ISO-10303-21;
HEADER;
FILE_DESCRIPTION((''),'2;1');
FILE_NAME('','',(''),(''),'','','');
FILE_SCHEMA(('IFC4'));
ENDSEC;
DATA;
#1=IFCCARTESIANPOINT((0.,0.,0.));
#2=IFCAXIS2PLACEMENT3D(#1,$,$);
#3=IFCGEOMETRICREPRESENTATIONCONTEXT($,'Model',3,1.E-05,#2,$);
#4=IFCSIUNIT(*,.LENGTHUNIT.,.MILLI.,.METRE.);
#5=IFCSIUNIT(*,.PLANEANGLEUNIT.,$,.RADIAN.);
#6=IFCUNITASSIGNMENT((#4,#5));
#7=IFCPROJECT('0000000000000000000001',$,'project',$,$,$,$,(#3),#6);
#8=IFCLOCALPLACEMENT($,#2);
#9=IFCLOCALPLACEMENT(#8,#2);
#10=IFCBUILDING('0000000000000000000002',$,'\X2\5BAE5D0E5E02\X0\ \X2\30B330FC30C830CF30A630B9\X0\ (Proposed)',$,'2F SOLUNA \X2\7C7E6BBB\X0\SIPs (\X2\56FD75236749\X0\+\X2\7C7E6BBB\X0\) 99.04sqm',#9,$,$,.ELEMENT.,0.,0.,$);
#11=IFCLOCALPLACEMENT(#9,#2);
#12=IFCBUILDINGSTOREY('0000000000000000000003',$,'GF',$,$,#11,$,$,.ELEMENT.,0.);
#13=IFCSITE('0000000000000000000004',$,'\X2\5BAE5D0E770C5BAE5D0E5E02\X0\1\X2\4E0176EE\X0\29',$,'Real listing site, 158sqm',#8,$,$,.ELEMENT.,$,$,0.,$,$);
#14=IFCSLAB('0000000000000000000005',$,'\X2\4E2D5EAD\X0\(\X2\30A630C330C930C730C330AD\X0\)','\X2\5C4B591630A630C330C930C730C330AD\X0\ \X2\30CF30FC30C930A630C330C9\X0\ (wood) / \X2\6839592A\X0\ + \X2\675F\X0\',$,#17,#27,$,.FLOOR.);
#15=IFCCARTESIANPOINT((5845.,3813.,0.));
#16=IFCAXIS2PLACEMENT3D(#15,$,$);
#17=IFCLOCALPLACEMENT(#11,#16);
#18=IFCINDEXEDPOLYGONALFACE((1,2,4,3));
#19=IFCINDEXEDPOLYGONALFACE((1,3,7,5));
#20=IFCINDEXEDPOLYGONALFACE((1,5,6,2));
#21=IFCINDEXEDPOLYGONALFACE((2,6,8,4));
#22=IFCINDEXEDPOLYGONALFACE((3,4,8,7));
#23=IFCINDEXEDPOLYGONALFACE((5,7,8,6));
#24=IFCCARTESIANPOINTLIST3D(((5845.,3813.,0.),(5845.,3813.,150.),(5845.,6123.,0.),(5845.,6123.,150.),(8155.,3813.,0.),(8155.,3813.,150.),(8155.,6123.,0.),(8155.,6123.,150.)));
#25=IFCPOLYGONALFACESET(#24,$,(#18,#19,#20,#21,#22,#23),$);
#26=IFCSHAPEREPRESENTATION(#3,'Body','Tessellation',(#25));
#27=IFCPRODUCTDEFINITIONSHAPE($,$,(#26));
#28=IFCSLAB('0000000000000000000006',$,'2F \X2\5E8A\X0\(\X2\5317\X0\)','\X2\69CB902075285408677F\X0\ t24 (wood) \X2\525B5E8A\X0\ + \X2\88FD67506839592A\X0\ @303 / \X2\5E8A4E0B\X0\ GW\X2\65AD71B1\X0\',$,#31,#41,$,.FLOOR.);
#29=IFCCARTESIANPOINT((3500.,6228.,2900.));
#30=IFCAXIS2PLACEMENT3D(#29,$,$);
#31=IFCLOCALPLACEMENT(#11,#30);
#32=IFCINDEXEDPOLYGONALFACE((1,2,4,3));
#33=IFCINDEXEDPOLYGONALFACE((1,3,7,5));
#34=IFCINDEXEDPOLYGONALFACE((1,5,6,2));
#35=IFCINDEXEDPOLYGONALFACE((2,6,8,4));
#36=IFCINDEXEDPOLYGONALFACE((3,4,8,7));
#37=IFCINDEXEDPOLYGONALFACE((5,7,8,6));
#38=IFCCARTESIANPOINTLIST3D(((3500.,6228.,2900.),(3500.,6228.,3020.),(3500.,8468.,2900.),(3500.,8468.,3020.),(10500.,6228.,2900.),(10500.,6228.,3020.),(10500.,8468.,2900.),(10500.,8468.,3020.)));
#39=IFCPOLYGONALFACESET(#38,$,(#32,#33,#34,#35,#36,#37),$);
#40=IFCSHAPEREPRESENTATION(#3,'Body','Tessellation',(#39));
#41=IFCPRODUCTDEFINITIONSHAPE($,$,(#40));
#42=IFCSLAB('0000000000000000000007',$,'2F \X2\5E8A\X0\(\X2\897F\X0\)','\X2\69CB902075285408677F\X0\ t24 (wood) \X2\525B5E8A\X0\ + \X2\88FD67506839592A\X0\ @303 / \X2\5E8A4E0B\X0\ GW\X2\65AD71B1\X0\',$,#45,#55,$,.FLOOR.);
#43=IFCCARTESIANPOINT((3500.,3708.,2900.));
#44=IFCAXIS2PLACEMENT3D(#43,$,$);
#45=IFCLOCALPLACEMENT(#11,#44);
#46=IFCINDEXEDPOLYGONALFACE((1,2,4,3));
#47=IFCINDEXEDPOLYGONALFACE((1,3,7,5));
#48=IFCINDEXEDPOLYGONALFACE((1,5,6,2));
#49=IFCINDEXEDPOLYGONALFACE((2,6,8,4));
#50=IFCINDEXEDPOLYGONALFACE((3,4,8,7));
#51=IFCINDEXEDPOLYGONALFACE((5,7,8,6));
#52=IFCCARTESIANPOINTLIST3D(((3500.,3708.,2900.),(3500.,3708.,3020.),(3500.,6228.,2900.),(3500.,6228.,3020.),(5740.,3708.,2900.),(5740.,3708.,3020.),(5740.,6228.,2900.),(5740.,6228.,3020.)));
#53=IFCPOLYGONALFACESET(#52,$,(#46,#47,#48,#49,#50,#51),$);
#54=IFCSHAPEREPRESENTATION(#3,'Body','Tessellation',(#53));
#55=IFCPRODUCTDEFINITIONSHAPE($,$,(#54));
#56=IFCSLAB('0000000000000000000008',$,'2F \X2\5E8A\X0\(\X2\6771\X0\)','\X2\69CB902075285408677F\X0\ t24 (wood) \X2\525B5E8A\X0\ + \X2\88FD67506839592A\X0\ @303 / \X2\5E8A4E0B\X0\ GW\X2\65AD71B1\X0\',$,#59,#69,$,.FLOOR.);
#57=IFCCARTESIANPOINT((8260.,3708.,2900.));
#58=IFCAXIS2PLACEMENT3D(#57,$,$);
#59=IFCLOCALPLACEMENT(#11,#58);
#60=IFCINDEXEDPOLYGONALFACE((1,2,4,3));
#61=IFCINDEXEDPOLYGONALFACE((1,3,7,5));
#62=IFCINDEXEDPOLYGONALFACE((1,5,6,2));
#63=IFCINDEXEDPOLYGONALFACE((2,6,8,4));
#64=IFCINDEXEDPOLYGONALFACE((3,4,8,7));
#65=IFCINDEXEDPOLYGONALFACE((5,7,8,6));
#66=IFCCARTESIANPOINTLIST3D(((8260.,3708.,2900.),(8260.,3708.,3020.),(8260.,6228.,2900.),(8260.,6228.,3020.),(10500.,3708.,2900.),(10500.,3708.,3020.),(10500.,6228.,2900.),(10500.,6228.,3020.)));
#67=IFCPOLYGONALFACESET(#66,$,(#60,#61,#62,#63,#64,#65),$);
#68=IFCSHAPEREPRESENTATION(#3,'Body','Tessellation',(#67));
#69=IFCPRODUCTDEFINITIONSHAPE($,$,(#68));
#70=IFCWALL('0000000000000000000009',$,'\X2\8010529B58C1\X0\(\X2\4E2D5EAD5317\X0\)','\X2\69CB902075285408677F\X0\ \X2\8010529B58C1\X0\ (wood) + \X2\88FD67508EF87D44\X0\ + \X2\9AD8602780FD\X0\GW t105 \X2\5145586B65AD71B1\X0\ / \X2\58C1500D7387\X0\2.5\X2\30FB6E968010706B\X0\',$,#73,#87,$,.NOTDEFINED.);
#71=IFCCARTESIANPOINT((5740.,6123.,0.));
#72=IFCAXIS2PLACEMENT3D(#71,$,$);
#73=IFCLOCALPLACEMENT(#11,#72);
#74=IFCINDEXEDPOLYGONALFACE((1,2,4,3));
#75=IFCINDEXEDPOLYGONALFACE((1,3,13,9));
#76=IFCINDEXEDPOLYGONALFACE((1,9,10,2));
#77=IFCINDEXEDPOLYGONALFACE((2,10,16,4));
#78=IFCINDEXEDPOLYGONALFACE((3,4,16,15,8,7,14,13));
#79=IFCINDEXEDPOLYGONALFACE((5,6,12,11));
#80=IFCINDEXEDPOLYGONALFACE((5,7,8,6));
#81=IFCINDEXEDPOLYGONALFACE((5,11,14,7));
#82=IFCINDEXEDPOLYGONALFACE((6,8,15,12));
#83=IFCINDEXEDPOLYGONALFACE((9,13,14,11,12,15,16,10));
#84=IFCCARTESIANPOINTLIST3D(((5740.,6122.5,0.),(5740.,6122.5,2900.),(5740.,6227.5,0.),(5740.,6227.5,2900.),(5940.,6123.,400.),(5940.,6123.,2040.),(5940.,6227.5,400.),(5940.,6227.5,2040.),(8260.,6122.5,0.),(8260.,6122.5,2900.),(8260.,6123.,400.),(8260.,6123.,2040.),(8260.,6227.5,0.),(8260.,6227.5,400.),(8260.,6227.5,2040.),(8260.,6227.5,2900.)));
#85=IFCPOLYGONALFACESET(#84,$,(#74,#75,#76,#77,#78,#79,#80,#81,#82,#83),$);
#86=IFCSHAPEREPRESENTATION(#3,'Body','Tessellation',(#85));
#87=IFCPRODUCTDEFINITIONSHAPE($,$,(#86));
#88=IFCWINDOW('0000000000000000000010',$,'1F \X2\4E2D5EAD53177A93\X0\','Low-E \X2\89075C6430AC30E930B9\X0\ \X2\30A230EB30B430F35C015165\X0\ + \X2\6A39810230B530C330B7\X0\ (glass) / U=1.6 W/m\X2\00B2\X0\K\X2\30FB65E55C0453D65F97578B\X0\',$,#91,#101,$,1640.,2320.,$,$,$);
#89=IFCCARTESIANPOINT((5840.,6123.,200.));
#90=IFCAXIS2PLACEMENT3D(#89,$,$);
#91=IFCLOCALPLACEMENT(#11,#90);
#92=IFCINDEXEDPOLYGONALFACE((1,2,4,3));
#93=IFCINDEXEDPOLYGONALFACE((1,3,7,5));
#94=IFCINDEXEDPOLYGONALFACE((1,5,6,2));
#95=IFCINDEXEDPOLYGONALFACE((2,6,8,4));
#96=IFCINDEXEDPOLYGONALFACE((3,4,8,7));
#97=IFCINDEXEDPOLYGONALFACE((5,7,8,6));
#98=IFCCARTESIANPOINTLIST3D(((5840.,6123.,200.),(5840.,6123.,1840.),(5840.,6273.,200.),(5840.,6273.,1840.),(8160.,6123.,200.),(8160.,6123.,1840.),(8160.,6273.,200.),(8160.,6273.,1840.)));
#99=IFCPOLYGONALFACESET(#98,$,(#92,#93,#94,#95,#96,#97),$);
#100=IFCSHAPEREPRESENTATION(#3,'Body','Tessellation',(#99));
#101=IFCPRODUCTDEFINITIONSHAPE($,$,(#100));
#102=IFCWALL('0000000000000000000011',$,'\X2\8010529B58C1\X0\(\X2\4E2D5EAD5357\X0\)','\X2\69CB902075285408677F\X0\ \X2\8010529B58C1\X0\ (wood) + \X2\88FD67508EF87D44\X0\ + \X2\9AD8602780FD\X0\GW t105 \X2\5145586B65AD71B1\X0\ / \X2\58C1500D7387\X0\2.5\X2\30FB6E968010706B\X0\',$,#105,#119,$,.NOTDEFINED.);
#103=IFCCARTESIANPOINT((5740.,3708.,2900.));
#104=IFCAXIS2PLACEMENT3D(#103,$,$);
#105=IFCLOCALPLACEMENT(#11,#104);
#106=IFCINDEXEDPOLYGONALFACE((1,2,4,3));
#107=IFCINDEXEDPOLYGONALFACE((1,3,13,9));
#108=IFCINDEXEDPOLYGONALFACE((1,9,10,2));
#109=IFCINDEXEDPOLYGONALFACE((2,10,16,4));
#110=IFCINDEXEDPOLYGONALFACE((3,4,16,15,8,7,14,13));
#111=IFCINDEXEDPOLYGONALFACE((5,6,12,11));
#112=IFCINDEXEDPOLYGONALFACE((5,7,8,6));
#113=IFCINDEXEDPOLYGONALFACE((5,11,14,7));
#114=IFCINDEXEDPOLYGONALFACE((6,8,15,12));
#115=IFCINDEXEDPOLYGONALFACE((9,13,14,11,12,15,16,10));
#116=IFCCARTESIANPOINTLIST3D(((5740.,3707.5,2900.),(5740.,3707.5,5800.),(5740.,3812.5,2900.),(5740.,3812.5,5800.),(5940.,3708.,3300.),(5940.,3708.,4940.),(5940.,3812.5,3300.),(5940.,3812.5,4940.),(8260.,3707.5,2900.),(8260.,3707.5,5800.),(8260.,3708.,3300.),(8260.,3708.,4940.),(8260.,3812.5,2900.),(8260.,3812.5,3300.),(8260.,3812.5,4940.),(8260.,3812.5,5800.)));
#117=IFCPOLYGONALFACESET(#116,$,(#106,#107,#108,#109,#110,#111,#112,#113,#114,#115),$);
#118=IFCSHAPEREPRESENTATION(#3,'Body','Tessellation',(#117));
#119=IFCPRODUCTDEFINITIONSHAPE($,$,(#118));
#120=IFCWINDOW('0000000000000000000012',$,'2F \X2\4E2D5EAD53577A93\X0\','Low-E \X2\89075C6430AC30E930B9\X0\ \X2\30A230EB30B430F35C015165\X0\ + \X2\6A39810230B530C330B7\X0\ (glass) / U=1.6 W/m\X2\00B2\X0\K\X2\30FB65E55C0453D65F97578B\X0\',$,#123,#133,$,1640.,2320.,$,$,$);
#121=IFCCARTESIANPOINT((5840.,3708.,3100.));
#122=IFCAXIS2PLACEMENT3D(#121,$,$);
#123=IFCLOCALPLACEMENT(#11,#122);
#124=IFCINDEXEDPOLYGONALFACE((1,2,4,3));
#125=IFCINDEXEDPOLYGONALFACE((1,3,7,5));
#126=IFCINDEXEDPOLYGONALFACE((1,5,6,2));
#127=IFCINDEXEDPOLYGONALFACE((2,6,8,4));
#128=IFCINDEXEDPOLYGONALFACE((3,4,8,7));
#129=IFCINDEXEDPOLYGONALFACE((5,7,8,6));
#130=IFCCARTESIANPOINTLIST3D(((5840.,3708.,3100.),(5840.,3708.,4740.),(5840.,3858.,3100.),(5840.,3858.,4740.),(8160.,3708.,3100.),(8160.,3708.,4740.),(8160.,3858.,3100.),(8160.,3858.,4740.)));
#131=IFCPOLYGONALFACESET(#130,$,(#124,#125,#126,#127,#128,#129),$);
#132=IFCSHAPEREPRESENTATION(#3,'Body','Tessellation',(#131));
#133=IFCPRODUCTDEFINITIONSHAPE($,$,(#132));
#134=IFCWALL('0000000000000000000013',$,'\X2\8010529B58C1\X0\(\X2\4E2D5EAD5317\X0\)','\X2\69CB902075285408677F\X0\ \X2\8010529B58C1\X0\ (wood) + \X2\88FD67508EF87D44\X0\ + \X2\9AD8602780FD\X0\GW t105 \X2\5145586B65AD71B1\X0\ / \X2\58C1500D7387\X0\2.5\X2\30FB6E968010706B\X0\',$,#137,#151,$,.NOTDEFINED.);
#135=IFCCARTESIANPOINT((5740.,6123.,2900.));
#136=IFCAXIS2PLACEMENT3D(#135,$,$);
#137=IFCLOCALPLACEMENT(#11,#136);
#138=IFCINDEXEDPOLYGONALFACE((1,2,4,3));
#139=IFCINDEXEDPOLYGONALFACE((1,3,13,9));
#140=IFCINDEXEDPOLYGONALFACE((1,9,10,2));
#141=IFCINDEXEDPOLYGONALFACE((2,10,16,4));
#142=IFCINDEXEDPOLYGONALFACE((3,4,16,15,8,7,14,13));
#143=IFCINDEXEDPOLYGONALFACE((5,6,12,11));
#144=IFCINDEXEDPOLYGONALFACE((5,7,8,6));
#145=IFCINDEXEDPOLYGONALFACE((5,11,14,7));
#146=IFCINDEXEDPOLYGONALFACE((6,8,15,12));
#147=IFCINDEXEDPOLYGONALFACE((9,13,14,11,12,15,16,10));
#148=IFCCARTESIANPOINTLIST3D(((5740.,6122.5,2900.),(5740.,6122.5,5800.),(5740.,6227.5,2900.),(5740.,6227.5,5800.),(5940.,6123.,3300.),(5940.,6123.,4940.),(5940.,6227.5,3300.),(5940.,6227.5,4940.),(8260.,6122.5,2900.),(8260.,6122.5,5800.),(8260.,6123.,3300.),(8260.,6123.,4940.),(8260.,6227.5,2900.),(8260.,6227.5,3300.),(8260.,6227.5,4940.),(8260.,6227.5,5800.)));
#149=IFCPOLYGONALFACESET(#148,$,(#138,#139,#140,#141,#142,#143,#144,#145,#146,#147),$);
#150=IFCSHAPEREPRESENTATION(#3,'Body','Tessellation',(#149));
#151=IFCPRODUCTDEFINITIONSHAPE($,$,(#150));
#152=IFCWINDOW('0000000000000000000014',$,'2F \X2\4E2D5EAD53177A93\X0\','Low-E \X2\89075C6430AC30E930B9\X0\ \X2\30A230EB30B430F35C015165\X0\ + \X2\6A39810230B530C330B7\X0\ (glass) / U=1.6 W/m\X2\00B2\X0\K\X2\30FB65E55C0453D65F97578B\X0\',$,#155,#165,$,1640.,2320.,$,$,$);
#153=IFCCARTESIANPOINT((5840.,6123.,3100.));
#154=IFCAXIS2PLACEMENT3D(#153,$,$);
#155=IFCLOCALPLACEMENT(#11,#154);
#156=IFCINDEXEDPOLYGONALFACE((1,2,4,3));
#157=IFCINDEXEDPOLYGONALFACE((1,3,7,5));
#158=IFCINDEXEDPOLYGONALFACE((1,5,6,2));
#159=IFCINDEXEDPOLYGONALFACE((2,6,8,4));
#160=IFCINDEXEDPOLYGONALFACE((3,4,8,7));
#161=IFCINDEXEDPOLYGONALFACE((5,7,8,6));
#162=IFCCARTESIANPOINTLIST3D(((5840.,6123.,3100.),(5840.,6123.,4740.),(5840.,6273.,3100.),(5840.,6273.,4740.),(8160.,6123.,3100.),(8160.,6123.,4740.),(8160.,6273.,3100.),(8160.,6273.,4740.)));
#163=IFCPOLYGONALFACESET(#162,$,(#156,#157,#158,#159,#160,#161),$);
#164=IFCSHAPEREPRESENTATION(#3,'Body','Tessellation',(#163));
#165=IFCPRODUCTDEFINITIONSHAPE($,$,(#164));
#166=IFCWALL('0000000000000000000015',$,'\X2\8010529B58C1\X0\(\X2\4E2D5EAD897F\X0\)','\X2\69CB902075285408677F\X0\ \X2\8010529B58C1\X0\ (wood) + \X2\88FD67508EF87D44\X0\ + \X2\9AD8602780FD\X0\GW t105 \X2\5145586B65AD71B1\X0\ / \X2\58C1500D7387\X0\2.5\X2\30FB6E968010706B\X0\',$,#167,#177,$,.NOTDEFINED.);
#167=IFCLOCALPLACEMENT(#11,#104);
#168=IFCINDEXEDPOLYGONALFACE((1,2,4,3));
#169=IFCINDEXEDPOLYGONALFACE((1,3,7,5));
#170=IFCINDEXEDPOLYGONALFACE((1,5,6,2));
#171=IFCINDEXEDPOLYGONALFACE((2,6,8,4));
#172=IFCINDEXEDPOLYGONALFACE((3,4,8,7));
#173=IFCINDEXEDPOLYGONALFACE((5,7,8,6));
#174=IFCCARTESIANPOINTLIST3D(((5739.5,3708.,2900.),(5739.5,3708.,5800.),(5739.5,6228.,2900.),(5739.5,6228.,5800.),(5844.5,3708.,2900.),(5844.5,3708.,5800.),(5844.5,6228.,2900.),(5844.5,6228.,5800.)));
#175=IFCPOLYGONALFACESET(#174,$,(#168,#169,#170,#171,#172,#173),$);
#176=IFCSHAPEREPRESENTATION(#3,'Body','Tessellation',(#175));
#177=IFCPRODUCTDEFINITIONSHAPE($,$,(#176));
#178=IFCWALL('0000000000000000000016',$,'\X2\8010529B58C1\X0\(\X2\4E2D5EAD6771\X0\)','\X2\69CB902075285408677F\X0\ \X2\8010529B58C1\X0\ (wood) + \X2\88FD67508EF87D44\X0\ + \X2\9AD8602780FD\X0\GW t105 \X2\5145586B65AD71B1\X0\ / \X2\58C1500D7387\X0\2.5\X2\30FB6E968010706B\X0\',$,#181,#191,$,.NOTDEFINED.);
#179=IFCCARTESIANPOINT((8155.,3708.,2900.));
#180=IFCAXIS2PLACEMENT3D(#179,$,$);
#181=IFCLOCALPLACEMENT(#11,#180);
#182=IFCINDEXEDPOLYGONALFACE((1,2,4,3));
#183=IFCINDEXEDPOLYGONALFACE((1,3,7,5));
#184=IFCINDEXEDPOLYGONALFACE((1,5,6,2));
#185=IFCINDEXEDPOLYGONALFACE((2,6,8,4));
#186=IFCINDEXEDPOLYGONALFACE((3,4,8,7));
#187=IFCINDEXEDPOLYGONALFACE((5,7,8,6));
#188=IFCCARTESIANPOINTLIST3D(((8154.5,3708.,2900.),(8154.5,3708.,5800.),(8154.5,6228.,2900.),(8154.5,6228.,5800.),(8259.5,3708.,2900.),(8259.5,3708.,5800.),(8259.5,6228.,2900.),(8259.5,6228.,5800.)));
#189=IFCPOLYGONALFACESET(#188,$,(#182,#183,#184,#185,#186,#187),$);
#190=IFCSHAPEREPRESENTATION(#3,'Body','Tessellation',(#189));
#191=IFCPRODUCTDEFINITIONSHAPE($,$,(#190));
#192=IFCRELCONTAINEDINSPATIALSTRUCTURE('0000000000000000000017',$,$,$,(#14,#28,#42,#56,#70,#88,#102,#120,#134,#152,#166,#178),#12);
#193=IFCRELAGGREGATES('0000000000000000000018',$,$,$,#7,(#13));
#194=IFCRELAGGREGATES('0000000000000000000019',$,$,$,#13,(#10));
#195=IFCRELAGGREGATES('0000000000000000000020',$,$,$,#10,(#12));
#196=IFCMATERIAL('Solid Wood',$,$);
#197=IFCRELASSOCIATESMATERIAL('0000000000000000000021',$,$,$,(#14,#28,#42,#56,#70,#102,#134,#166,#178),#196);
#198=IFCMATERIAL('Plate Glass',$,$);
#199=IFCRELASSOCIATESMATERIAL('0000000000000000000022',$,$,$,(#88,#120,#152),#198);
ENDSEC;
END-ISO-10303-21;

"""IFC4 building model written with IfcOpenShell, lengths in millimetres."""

from ifc_helpers import new_model, si_unit, frame, frame_2d, origin, place, context, project, spatial, rectangle, extrude, material, element, fill, save


model = new_model("IFC4")

# Units and contexts
model_context = context("Model", 3, precision=1e-05, world=origin())
ifc_project = project(units=[si_unit("LENGTHUNIT", "METRE", prefix="MILLI"), si_unit("PLANEANGLEUNIT", "RADIAN")], contexts=[model_context])

# Site, building, storey
site_placement = place(None, origin())
site = spatial("IfcSite", under=ifc_project, at=site_placement, Name="宮崎県宮崎市1丁目29", ObjectType="Real listing site, 158sqm", CompositionType="ELEMENT", RefElevation=0.0)
building_placement = place(site_placement, origin())
building = spatial("IfcBuilding", under=site, at=building_placement, Name="宮崎市 コートハウス (Proposed)", ObjectType="2F SOLUNA 籾殻SIPs (国産杉+籾殻) 99.04sqm", CompositionType="ELEMENT", ElevationOfRefHeight=0.0, ElevationOfTerrain=0.0)
storey_placement = place(building_placement, origin())
storey = spatial("IfcBuildingStorey", under=building, at=storey_placement, Name="GF", CompositionType="ELEMENT", Elevation=0.0)

# Slabs
ifc_material_1 = material(Name="Solid Wood")
slab_1_placement = place(storey_placement, frame((5845.0, 3813.0, 0.0)))
element("IfcSlab", 1, at=slab_1_placement, inside=storey, material=ifc_material_1, Name="中庭(ウッドデッキ)", Description="屋外ウッドデッキ ハードウッド (wood) / 根太 + 束", PredefinedType="FLOOR", context=model_context, shape_type="SweptSolid", body=[
    extrude(rectangle(XDim=2310.0, YDim=2310.0, at=frame_2d((1155.0, 1155.0))), frame((5845.0, 3813.0, 0.0)), (0.0, 0.0, 1.0), 150.0),
])
slab_2_placement = place(storey_placement, frame((3500.0, 6228.0, 2900.0)))
element("IfcSlab", 2, at=slab_2_placement, inside=storey, material=ifc_material_1, Name="2F 床(北)", Description="構造用合板 t24 (wood) 剛床 + 製材根太 @303 / 床下 GW断熱", PredefinedType="FLOOR", context=model_context, shape_type="SweptSolid", body=[
    extrude(rectangle(XDim=7000.0, YDim=2240.0, at=frame_2d((3500.0, 1120.0))), frame((3500.0, 6228.0, 2900.0)), (0.0, 0.0, 1.0), 120.0),
])
slab_3_placement = place(storey_placement, frame((3500.0, 3708.0, 2900.0)))
element("IfcSlab", 3, at=slab_3_placement, inside=storey, material=ifc_material_1, Name="2F 床(西)", Description="構造用合板 t24 (wood) 剛床 + 製材根太 @303 / 床下 GW断熱", PredefinedType="FLOOR", context=model_context, shape_type="SweptSolid", body=[
    extrude(rectangle(XDim=2240.0, YDim=2520.0, at=frame_2d((1120.0, 1260.0))), frame((3500.0, 3708.0, 2900.0)), (0.0, 0.0, 1.0), 120.0),
])
slab_4_placement = place(storey_placement, frame((8260.0, 3708.0, 2900.0)))
element("IfcSlab", 4, at=slab_4_placement, inside=storey, material=ifc_material_1, Name="2F 床(東)", Description="構造用合板 t24 (wood) 剛床 + 製材根太 @303 / 床下 GW断熱", PredefinedType="FLOOR", context=model_context, shape_type="SweptSolid", body=[
    extrude(rectangle(XDim=2240.0, YDim=2520.0, at=frame_2d((1120.0, 1260.0))), frame((8260.0, 3708.0, 2900.0)), (0.0, 0.0, 1.0), 120.0),
])

# Wall, opening, window
wall_1_placement = place(storey_placement, frame((5740.0, 6123.0, 0.0)))
wall_1 = element("IfcWall", 5, at=wall_1_placement, inside=storey, material=ifc_material_1, Name="耐力壁(中庭北)", Description="構造用合板 耐力壁 (wood) + 製材軸組 + 高性能GW t105 充填断熱 / 壁倍率2.5・準耐火", PredefinedType="NOTDEFINED", context=model_context, shape_type="SweptSolid", body=[
    extrude(rectangle(XDim=2520.0, YDim=105.0, at=frame_2d((1260.0, 52.0))), frame((5740.0, 6123.0, 0.0)), (0.0, 0.0, 1.0), 2900.0),
])
opening_1_placement = place(storey_placement, frame((5840.0, 6123.0, 200.0)))
opening_1 = element("IfcOpeningElement", 6, at=opening_1_placement, cuts=wall_1, PredefinedType="NOTDEFINED", context=model_context, shape_type="SweptSolid", body=[
    extrude(rectangle(XDim=2320.0, YDim=150.0, at=frame_2d((1160.0, 75.0))), frame((5840.0, 6123.0, 200.0)), (0.0, 0.0, 1.0), 1640.0),
])
ifc_material_2 = material(Name="Plate Glass")
window_1_placement = place(storey_placement, frame((5840.0, 6123.0, 200.0)))
window_1 = element("IfcWindow", 7, at=window_1_placement, inside=storey, material=ifc_material_2, Name="1F 中庭北窓", Description="Low-E 複層ガラス アルゴン封入 + 樹脂サッシ (glass) / U=1.6 W/m²K・日射取得型", OverallHeight=1640.0, OverallWidth=2320.0, context=model_context, shape_type="SweptSolid", body=[
    extrude(rectangle(XDim=2320.0, YDim=150.0, at=frame_2d((1160.0, 75.0))), frame((5840.0, 6123.0, 200.0)), (0.0, 0.0, 1.0), 1640.0),
])
fill(opening_1, window_1)

# Walls, openings, windows
wall_2_placement = place(storey_placement, frame((5740.0, 3708.0, 2900.0)))
wall_2 = element("IfcWall", 8, at=wall_2_placement, inside=storey, material=ifc_material_1, Name="耐力壁(中庭南)", Description="構造用合板 耐力壁 (wood) + 製材軸組 + 高性能GW t105 充填断熱 / 壁倍率2.5・準耐火", PredefinedType="NOTDEFINED", context=model_context, shape_type="SweptSolid", body=[
    extrude(rectangle(XDim=2520.0, YDim=105.0, at=frame_2d((1260.0, 52.0))), frame((5740.0, 3708.0, 2900.0)), (0.0, 0.0, 1.0), 2900.0),
])
opening_2_placement = place(storey_placement, frame((5840.0, 3708.0, 3100.0)))
opening_2 = element("IfcOpeningElement", 9, at=opening_2_placement, cuts=wall_2, PredefinedType="NOTDEFINED", context=model_context, shape_type="SweptSolid", body=[
    extrude(rectangle(XDim=2320.0, YDim=150.0, at=frame_2d((1160.0, 75.0))), frame((5840.0, 3708.0, 3100.0)), (0.0, 0.0, 1.0), 1640.0),
])
window_2_placement = place(storey_placement, frame((5840.0, 3708.0, 3100.0)))
window_2 = element("IfcWindow", 10, at=window_2_placement, inside=storey, material=ifc_material_2, Name="2F 中庭南窓", Description="Low-E 複層ガラス アルゴン封入 + 樹脂サッシ (glass) / U=1.6 W/m²K・日射取得型", OverallHeight=1640.0, OverallWidth=2320.0, context=model_context, shape_type="SweptSolid", body=[
    extrude(rectangle(XDim=2320.0, YDim=150.0, at=frame_2d((1160.0, 75.0))), frame((5840.0, 3708.0, 3100.0)), (0.0, 0.0, 1.0), 1640.0),
])
fill(opening_2, window_2)
wall_3_placement = place(storey_placement, frame((5740.0, 6123.0, 2900.0)))
wall_3 = element("IfcWall", 11, at=wall_3_placement, inside=storey, material=ifc_material_1, Name="耐力壁(中庭北)", Description="構造用合板 耐力壁 (wood) + 製材軸組 + 高性能GW t105 充填断熱 / 壁倍率2.5・準耐火", PredefinedType="NOTDEFINED", context=model_context, shape_type="SweptSolid", body=[
    extrude(rectangle(XDim=2520.0, YDim=105.0, at=frame_2d((1260.0, 52.0))), frame((5740.0, 6123.0, 2900.0)), (0.0, 0.0, 1.0), 2900.0),
])
opening_3_placement = place(storey_placement, frame((5840.0, 6123.0, 3100.0)))
opening_3 = element("IfcOpeningElement", 12, at=opening_3_placement, cuts=wall_3, PredefinedType="NOTDEFINED", context=model_context, shape_type="SweptSolid", body=[
    extrude(rectangle(XDim=2320.0, YDim=150.0, at=frame_2d((1160.0, 75.0))), frame((5840.0, 6123.0, 3100.0)), (0.0, 0.0, 1.0), 1640.0),
])
window_3_placement = place(storey_placement, frame((5840.0, 6123.0, 3100.0)))
window_3 = element("IfcWindow", 13, at=window_3_placement, inside=storey, material=ifc_material_2, Name="2F 中庭北窓", Description="Low-E 複層ガラス アルゴン封入 + 樹脂サッシ (glass) / U=1.6 W/m²K・日射取得型", OverallHeight=1640.0, OverallWidth=2320.0, context=model_context, shape_type="SweptSolid", body=[
    extrude(rectangle(XDim=2320.0, YDim=150.0, at=frame_2d((1160.0, 75.0))), frame((5840.0, 6123.0, 3100.0)), (0.0, 0.0, 1.0), 1640.0),
])
fill(opening_3, window_3)

# Walls
wall_4_placement = place(storey_placement, frame((5740.0, 3708.0, 2900.0)))
element("IfcWall", 14, at=wall_4_placement, inside=storey, material=ifc_material_1, Name="耐力壁(中庭西)", Description="構造用合板 耐力壁 (wood) + 製材軸組 + 高性能GW t105 充填断熱 / 壁倍率2.5・準耐火", PredefinedType="NOTDEFINED", context=model_context, shape_type="SweptSolid", body=[
    extrude(rectangle(XDim=105.0, YDim=2520.0, at=frame_2d((52.0, 1260.0))), frame((5740.0, 3708.0, 2900.0)), (0.0, 0.0, 1.0), 2900.0),
])
wall_5_placement = place(storey_placement, frame((8155.0, 3708.0, 2900.0)))
element("IfcWall", 15, at=wall_5_placement, inside=storey, material=ifc_material_1, Name="耐力壁(中庭東)", Description="構造用合板 耐力壁 (wood) + 製材軸組 + 高性能GW t105 充填断熱 / 壁倍率2.5・準耐火", PredefinedType="NOTDEFINED", context=model_context, shape_type="SweptSolid", body=[
    extrude(rectangle(XDim=105.0, YDim=2520.0, at=frame_2d((52.0, 1260.0))), frame((8155.0, 3708.0, 2900.0)), (0.0, 0.0, 1.0), 2900.0),
])

save(model, "model.ifc")
